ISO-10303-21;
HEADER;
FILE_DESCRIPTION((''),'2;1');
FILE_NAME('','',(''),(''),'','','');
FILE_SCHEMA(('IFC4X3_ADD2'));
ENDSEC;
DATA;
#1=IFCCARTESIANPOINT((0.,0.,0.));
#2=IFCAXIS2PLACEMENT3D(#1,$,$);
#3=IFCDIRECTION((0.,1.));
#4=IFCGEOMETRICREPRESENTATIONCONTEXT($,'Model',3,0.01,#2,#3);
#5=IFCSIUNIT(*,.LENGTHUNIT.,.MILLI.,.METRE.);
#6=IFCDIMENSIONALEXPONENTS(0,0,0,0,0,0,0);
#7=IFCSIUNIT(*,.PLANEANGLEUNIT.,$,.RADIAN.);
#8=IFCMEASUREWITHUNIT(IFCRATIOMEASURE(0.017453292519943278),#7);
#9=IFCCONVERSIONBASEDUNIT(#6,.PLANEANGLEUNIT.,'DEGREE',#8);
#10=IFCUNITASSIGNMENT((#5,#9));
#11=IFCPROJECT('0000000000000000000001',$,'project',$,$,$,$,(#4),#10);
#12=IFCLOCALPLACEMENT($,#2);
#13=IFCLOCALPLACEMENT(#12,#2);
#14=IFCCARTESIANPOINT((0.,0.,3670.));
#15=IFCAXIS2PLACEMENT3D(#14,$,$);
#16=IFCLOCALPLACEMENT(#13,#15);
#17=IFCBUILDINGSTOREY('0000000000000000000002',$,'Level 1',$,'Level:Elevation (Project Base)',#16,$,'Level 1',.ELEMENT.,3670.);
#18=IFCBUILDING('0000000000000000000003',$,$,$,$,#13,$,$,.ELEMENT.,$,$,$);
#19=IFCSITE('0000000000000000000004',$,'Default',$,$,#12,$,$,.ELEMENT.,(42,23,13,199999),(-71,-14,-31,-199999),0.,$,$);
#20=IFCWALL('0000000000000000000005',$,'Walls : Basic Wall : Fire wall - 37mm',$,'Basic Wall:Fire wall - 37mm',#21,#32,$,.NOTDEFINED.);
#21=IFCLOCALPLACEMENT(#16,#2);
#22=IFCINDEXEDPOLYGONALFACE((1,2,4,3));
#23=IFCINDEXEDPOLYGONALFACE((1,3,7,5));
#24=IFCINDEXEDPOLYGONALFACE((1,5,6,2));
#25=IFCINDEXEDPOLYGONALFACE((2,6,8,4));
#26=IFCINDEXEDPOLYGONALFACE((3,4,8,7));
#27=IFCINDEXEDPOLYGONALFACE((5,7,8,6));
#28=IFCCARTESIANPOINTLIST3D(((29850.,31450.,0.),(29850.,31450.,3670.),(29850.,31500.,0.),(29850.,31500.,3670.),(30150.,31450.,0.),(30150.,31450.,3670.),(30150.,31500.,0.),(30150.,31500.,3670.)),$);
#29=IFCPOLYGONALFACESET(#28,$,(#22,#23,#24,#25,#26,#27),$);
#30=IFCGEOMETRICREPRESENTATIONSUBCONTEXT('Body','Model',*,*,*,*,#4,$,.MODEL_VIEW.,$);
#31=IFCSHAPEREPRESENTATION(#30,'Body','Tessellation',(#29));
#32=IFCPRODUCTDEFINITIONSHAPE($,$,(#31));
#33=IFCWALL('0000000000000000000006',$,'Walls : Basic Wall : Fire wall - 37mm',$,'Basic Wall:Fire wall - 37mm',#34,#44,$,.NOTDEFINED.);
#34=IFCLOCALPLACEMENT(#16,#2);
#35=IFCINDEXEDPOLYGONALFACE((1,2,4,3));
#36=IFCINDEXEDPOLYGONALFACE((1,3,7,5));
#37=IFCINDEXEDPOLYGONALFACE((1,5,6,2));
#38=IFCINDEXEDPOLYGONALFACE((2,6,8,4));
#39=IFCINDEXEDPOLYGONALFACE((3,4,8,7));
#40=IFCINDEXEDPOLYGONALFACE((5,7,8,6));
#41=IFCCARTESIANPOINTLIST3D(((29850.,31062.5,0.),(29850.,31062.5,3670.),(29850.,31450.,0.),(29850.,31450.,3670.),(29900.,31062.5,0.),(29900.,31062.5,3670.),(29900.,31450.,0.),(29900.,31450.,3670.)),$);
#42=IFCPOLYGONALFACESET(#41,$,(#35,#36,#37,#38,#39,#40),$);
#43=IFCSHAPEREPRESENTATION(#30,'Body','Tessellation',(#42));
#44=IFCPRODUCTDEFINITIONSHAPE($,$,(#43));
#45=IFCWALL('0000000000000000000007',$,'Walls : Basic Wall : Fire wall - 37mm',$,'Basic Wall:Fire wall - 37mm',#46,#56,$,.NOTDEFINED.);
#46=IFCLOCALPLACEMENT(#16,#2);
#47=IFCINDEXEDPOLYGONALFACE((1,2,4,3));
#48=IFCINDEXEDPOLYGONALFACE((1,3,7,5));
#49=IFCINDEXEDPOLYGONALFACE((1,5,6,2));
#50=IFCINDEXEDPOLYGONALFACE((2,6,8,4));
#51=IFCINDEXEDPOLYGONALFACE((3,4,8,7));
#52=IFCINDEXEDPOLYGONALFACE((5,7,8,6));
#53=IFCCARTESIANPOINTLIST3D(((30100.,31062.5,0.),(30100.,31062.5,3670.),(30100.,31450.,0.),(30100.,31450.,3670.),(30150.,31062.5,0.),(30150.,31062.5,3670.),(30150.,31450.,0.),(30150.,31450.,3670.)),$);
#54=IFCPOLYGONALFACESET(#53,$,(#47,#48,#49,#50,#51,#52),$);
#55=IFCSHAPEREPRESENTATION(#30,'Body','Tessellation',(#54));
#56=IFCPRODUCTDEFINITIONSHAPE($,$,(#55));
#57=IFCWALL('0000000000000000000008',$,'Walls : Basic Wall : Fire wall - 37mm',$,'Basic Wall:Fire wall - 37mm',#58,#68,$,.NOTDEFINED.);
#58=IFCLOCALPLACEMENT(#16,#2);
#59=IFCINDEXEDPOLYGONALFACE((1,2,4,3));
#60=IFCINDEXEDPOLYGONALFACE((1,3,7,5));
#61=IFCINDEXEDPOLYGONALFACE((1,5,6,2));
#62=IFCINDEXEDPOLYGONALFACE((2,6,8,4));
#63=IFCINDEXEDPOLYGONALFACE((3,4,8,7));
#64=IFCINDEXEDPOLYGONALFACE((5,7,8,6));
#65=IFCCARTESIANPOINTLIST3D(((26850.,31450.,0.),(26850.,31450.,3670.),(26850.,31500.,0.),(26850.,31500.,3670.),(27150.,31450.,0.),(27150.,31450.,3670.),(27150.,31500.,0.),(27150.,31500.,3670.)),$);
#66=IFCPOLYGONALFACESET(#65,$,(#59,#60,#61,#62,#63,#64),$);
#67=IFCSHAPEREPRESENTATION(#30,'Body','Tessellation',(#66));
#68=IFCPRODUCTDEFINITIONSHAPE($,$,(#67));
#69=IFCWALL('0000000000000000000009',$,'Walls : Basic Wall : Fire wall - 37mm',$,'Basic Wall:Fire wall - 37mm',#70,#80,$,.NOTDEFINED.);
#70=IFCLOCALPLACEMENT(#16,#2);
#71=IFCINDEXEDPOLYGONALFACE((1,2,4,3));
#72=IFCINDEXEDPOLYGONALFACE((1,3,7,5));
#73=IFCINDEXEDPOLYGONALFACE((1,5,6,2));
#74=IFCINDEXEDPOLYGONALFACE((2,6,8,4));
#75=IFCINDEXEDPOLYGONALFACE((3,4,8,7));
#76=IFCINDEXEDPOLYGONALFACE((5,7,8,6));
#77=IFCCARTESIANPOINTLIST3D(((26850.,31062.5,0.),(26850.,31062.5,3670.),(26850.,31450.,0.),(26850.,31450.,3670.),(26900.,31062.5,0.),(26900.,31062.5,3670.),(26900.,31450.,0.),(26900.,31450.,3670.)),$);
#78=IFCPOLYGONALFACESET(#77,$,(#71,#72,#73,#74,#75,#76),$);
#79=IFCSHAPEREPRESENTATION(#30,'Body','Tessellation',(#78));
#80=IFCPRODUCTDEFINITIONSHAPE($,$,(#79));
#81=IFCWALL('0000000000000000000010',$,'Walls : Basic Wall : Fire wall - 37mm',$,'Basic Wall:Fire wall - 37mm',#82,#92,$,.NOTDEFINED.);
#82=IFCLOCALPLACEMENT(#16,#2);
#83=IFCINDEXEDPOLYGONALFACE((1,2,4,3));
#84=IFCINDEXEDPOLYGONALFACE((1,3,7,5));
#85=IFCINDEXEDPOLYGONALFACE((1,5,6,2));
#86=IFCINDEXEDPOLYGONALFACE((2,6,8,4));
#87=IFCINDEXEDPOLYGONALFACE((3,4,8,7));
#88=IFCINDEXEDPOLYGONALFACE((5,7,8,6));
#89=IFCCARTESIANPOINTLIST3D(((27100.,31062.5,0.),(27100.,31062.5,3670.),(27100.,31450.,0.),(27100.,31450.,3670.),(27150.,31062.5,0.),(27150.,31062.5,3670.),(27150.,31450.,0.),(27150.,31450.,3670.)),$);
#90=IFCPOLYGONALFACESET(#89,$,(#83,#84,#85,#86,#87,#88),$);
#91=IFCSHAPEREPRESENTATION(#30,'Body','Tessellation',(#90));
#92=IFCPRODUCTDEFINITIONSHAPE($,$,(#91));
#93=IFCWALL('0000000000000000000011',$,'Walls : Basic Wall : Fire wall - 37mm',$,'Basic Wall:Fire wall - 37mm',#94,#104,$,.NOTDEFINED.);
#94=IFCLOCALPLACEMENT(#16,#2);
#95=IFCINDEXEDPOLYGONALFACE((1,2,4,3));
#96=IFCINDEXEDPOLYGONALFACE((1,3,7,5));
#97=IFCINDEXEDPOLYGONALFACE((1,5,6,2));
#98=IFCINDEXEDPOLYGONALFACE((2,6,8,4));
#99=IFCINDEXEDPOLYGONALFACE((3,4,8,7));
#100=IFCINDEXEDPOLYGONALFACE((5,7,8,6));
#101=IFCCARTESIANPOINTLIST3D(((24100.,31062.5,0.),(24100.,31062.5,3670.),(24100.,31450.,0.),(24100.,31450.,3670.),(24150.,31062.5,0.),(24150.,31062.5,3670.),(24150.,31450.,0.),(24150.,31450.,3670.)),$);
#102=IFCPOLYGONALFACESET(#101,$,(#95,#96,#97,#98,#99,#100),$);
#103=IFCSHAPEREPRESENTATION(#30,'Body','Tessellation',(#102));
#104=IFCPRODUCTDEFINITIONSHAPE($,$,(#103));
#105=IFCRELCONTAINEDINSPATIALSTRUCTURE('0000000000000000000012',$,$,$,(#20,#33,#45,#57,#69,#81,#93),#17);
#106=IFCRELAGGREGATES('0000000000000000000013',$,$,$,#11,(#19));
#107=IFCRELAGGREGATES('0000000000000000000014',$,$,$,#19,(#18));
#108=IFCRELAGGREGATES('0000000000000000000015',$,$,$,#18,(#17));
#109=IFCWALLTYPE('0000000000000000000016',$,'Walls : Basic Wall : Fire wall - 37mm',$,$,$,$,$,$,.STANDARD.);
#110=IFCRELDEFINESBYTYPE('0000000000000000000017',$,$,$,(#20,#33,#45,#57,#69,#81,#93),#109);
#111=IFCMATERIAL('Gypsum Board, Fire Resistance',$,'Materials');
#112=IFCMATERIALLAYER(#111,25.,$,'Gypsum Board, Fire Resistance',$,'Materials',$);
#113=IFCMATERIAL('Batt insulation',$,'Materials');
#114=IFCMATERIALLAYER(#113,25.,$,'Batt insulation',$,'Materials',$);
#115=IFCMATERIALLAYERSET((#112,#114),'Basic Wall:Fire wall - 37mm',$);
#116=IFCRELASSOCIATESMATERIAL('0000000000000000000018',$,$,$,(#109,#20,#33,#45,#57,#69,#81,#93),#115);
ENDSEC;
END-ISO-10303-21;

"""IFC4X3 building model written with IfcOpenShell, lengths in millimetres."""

from ifc_helpers import new_model, entity, si_unit, converted_unit, direction, frame, frame_2d, origin, place, context, subcontext, project, spatial, rectangle, extrude, material, layer, layer_set, type_object, element, save


model = new_model("IFC4X3")

# Units and contexts
model_context = context("Model", 3, precision=0.01, world=origin(), true_north=direction((0.0, 1.0)))
body_context = subcontext(model_context, "Body", "Model", "MODEL_VIEW")
ifc_project = project(units=[si_unit("LENGTHUNIT", "METRE", prefix="MILLI"), converted_unit("PLANEANGLEUNIT", "DEGREE", entity("IfcRatioMeasure", 0.017453292519943278), si_unit("PLANEANGLEUNIT", "RADIAN"), dimensions=[0, 0, 0, 0, 0, 0, 0])], contexts=[model_context])

# Site, building, storey
site_placement = place(None, origin())
site = spatial("IfcSite", under=ifc_project, at=site_placement, Name="Default", CompositionType="ELEMENT", RefLatitude=(42, 23, 13, 199999), RefLongitude=(-71, -14, -31, -199999), RefElevation=0.0)
building_placement = place(site_placement, origin())
building = spatial("IfcBuilding", under=site, at=building_placement, CompositionType="ELEMENT")
storey_placement = place(building_placement, frame((0.0, 0.0, 3670.0)))
storey = spatial("IfcBuildingStorey", under=building, at=storey_placement, Name="Level 1", ObjectType="Level:Elevation (Project Base)", LongName="Level 1", CompositionType="ELEMENT", Elevation=3670.0)

# Walls
ifc_material_1 = material(Name="Gypsum Board, Fire Resistance", Category="Materials")
ifc_layer_1 = layer(ifc_material_1, 25.0, Name="Gypsum Board, Fire Resistance", Category="Materials")
ifc_material_2 = material(Name="Batt insulation", Category="Materials")
ifc_layer_2 = layer(ifc_material_2, 25.0, Name="Batt insulation", Category="Materials")
ifc_layer_set = layer_set([ifc_layer_1, ifc_layer_2], Name="Basic Wall:Fire wall - 37mm")
wall_type = type_object("IfcWallType", Name="Walls : Basic Wall : Fire wall - 37mm", PredefinedType="STANDARD", material=ifc_layer_set)
wall_1_placement = place(storey_placement, frame((29850.0, 31475.0, 0.0)))
element("IfcWall", 1, at=wall_1_placement, inside=storey, type_object=wall_type, material=ifc_layer_set, Name="Walls : Basic Wall : Fire wall - 37mm", ObjectType="Basic Wall:Fire wall - 37mm", PredefinedType="NOTDEFINED", context=body_context, shape_type="SweptSolid", body=[
    extrude(rectangle(XDim=300.0, YDim=50.0, at=frame_2d((150.0, 0.0), x_axis=(-1.0, 0.0))), origin(), (0.0, 0.0, 1.0), 3670.0),
])
wall_2_placement = place(storey_placement, frame((29875.0, 31450.0, 0.0), z_axis=(0.0, 0.0, 1.0), x_axis=(0.0, -1.0, 0.0)))
element("IfcWall", 2, at=wall_2_placement, inside=storey, type_object=wall_type, material=ifc_layer_set, Name="Walls : Basic Wall : Fire wall - 37mm", ObjectType="Basic Wall:Fire wall - 37mm", PredefinedType="NOTDEFINED", context=body_context, shape_type="SweptSolid", body=[
    extrude(rectangle(XDim=387.5, YDim=50.0, at=frame_2d((193.7, 0.0), x_axis=(-1.0, 0.0))), origin(), (0.0, 0.0, 1.0), 3670.0),
])
wall_3_placement = place(storey_placement, frame((30125.0, 31450.0, 0.0), z_axis=(0.0, 0.0, 1.0), x_axis=(0.0, -1.0, 0.0)))
element("IfcWall", 3, at=wall_3_placement, inside=storey, type_object=wall_type, material=ifc_layer_set, Name="Walls : Basic Wall : Fire wall - 37mm", ObjectType="Basic Wall:Fire wall - 37mm", PredefinedType="NOTDEFINED", context=body_context, shape_type="SweptSolid", body=[
    extrude(rectangle(XDim=387.5, YDim=50.0, at=frame_2d((193.7, 0.0), x_axis=(-1.0, 0.0))), origin(), (0.0, 0.0, 1.0), 3670.0),
])
wall_4_placement = place(storey_placement, frame((26850.0, 31475.0, 0.0)))
element("IfcWall", 4, at=wall_4_placement, inside=storey, type_object=wall_type, material=ifc_layer_set, Name="Walls : Basic Wall : Fire wall - 37mm", ObjectType="Basic Wall:Fire wall - 37mm", PredefinedType="NOTDEFINED", context=body_context, shape_type="SweptSolid", body=[
    extrude(rectangle(XDim=300.0, YDim=50.0, at=frame_2d((150.0, 0.0), x_axis=(-1.0, 0.0))), origin(), (0.0, 0.0, 1.0), 3670.0),
])
wall_5_placement = place(storey_placement, frame((26875.0, 31450.0, 0.0), z_axis=(0.0, 0.0, 1.0), x_axis=(0.0, -1.0, 0.0)))
element("IfcWall", 5, at=wall_5_placement, inside=storey, type_object=wall_type, material=ifc_layer_set, Name="Walls : Basic Wall : Fire wall - 37mm", ObjectType="Basic Wall:Fire wall - 37mm", PredefinedType="NOTDEFINED", context=body_context, shape_type="SweptSolid", body=[
    extrude(rectangle(XDim=387.5, YDim=50.0, at=frame_2d((193.7, 0.0), x_axis=(-1.0, 0.0))), origin(), (0.0, 0.0, 1.0), 3670.0),
])
for number, where, z_axis, x_axis, name in (
    (6, (27125.0, 31450.0, 0.0), (0.0, 0.0, 1.0), (0.0, -1.0, 0.0), "Walls : Basic Wall : Fire wall - 37mm"),
    (7, (24125.0, 31450.0, 0.0), (0.0, 0.0, 1.0), (0.0, -1.0, 0.0), "Walls : Basic Wall : Fire wall - 37mm"),
):
    element("IfcWall", number, at=place(storey_placement, frame(where, z_axis=z_axis, x_axis=x_axis)), inside=storey, type_object=wall_type, material=ifc_layer_set, Name=name, ObjectType="Basic Wall:Fire wall - 37mm", PredefinedType="NOTDEFINED", context=body_context, shape_type="SweptSolid", body=[
        extrude(rectangle(XDim=387.5, YDim=50.0, at=frame_2d((193.7, 0.0), x_axis=(-1.0, 0.0))), origin(), (0.0, 0.0, 1.0), 3670.0),
    ])

save(model, "model.ifc")
